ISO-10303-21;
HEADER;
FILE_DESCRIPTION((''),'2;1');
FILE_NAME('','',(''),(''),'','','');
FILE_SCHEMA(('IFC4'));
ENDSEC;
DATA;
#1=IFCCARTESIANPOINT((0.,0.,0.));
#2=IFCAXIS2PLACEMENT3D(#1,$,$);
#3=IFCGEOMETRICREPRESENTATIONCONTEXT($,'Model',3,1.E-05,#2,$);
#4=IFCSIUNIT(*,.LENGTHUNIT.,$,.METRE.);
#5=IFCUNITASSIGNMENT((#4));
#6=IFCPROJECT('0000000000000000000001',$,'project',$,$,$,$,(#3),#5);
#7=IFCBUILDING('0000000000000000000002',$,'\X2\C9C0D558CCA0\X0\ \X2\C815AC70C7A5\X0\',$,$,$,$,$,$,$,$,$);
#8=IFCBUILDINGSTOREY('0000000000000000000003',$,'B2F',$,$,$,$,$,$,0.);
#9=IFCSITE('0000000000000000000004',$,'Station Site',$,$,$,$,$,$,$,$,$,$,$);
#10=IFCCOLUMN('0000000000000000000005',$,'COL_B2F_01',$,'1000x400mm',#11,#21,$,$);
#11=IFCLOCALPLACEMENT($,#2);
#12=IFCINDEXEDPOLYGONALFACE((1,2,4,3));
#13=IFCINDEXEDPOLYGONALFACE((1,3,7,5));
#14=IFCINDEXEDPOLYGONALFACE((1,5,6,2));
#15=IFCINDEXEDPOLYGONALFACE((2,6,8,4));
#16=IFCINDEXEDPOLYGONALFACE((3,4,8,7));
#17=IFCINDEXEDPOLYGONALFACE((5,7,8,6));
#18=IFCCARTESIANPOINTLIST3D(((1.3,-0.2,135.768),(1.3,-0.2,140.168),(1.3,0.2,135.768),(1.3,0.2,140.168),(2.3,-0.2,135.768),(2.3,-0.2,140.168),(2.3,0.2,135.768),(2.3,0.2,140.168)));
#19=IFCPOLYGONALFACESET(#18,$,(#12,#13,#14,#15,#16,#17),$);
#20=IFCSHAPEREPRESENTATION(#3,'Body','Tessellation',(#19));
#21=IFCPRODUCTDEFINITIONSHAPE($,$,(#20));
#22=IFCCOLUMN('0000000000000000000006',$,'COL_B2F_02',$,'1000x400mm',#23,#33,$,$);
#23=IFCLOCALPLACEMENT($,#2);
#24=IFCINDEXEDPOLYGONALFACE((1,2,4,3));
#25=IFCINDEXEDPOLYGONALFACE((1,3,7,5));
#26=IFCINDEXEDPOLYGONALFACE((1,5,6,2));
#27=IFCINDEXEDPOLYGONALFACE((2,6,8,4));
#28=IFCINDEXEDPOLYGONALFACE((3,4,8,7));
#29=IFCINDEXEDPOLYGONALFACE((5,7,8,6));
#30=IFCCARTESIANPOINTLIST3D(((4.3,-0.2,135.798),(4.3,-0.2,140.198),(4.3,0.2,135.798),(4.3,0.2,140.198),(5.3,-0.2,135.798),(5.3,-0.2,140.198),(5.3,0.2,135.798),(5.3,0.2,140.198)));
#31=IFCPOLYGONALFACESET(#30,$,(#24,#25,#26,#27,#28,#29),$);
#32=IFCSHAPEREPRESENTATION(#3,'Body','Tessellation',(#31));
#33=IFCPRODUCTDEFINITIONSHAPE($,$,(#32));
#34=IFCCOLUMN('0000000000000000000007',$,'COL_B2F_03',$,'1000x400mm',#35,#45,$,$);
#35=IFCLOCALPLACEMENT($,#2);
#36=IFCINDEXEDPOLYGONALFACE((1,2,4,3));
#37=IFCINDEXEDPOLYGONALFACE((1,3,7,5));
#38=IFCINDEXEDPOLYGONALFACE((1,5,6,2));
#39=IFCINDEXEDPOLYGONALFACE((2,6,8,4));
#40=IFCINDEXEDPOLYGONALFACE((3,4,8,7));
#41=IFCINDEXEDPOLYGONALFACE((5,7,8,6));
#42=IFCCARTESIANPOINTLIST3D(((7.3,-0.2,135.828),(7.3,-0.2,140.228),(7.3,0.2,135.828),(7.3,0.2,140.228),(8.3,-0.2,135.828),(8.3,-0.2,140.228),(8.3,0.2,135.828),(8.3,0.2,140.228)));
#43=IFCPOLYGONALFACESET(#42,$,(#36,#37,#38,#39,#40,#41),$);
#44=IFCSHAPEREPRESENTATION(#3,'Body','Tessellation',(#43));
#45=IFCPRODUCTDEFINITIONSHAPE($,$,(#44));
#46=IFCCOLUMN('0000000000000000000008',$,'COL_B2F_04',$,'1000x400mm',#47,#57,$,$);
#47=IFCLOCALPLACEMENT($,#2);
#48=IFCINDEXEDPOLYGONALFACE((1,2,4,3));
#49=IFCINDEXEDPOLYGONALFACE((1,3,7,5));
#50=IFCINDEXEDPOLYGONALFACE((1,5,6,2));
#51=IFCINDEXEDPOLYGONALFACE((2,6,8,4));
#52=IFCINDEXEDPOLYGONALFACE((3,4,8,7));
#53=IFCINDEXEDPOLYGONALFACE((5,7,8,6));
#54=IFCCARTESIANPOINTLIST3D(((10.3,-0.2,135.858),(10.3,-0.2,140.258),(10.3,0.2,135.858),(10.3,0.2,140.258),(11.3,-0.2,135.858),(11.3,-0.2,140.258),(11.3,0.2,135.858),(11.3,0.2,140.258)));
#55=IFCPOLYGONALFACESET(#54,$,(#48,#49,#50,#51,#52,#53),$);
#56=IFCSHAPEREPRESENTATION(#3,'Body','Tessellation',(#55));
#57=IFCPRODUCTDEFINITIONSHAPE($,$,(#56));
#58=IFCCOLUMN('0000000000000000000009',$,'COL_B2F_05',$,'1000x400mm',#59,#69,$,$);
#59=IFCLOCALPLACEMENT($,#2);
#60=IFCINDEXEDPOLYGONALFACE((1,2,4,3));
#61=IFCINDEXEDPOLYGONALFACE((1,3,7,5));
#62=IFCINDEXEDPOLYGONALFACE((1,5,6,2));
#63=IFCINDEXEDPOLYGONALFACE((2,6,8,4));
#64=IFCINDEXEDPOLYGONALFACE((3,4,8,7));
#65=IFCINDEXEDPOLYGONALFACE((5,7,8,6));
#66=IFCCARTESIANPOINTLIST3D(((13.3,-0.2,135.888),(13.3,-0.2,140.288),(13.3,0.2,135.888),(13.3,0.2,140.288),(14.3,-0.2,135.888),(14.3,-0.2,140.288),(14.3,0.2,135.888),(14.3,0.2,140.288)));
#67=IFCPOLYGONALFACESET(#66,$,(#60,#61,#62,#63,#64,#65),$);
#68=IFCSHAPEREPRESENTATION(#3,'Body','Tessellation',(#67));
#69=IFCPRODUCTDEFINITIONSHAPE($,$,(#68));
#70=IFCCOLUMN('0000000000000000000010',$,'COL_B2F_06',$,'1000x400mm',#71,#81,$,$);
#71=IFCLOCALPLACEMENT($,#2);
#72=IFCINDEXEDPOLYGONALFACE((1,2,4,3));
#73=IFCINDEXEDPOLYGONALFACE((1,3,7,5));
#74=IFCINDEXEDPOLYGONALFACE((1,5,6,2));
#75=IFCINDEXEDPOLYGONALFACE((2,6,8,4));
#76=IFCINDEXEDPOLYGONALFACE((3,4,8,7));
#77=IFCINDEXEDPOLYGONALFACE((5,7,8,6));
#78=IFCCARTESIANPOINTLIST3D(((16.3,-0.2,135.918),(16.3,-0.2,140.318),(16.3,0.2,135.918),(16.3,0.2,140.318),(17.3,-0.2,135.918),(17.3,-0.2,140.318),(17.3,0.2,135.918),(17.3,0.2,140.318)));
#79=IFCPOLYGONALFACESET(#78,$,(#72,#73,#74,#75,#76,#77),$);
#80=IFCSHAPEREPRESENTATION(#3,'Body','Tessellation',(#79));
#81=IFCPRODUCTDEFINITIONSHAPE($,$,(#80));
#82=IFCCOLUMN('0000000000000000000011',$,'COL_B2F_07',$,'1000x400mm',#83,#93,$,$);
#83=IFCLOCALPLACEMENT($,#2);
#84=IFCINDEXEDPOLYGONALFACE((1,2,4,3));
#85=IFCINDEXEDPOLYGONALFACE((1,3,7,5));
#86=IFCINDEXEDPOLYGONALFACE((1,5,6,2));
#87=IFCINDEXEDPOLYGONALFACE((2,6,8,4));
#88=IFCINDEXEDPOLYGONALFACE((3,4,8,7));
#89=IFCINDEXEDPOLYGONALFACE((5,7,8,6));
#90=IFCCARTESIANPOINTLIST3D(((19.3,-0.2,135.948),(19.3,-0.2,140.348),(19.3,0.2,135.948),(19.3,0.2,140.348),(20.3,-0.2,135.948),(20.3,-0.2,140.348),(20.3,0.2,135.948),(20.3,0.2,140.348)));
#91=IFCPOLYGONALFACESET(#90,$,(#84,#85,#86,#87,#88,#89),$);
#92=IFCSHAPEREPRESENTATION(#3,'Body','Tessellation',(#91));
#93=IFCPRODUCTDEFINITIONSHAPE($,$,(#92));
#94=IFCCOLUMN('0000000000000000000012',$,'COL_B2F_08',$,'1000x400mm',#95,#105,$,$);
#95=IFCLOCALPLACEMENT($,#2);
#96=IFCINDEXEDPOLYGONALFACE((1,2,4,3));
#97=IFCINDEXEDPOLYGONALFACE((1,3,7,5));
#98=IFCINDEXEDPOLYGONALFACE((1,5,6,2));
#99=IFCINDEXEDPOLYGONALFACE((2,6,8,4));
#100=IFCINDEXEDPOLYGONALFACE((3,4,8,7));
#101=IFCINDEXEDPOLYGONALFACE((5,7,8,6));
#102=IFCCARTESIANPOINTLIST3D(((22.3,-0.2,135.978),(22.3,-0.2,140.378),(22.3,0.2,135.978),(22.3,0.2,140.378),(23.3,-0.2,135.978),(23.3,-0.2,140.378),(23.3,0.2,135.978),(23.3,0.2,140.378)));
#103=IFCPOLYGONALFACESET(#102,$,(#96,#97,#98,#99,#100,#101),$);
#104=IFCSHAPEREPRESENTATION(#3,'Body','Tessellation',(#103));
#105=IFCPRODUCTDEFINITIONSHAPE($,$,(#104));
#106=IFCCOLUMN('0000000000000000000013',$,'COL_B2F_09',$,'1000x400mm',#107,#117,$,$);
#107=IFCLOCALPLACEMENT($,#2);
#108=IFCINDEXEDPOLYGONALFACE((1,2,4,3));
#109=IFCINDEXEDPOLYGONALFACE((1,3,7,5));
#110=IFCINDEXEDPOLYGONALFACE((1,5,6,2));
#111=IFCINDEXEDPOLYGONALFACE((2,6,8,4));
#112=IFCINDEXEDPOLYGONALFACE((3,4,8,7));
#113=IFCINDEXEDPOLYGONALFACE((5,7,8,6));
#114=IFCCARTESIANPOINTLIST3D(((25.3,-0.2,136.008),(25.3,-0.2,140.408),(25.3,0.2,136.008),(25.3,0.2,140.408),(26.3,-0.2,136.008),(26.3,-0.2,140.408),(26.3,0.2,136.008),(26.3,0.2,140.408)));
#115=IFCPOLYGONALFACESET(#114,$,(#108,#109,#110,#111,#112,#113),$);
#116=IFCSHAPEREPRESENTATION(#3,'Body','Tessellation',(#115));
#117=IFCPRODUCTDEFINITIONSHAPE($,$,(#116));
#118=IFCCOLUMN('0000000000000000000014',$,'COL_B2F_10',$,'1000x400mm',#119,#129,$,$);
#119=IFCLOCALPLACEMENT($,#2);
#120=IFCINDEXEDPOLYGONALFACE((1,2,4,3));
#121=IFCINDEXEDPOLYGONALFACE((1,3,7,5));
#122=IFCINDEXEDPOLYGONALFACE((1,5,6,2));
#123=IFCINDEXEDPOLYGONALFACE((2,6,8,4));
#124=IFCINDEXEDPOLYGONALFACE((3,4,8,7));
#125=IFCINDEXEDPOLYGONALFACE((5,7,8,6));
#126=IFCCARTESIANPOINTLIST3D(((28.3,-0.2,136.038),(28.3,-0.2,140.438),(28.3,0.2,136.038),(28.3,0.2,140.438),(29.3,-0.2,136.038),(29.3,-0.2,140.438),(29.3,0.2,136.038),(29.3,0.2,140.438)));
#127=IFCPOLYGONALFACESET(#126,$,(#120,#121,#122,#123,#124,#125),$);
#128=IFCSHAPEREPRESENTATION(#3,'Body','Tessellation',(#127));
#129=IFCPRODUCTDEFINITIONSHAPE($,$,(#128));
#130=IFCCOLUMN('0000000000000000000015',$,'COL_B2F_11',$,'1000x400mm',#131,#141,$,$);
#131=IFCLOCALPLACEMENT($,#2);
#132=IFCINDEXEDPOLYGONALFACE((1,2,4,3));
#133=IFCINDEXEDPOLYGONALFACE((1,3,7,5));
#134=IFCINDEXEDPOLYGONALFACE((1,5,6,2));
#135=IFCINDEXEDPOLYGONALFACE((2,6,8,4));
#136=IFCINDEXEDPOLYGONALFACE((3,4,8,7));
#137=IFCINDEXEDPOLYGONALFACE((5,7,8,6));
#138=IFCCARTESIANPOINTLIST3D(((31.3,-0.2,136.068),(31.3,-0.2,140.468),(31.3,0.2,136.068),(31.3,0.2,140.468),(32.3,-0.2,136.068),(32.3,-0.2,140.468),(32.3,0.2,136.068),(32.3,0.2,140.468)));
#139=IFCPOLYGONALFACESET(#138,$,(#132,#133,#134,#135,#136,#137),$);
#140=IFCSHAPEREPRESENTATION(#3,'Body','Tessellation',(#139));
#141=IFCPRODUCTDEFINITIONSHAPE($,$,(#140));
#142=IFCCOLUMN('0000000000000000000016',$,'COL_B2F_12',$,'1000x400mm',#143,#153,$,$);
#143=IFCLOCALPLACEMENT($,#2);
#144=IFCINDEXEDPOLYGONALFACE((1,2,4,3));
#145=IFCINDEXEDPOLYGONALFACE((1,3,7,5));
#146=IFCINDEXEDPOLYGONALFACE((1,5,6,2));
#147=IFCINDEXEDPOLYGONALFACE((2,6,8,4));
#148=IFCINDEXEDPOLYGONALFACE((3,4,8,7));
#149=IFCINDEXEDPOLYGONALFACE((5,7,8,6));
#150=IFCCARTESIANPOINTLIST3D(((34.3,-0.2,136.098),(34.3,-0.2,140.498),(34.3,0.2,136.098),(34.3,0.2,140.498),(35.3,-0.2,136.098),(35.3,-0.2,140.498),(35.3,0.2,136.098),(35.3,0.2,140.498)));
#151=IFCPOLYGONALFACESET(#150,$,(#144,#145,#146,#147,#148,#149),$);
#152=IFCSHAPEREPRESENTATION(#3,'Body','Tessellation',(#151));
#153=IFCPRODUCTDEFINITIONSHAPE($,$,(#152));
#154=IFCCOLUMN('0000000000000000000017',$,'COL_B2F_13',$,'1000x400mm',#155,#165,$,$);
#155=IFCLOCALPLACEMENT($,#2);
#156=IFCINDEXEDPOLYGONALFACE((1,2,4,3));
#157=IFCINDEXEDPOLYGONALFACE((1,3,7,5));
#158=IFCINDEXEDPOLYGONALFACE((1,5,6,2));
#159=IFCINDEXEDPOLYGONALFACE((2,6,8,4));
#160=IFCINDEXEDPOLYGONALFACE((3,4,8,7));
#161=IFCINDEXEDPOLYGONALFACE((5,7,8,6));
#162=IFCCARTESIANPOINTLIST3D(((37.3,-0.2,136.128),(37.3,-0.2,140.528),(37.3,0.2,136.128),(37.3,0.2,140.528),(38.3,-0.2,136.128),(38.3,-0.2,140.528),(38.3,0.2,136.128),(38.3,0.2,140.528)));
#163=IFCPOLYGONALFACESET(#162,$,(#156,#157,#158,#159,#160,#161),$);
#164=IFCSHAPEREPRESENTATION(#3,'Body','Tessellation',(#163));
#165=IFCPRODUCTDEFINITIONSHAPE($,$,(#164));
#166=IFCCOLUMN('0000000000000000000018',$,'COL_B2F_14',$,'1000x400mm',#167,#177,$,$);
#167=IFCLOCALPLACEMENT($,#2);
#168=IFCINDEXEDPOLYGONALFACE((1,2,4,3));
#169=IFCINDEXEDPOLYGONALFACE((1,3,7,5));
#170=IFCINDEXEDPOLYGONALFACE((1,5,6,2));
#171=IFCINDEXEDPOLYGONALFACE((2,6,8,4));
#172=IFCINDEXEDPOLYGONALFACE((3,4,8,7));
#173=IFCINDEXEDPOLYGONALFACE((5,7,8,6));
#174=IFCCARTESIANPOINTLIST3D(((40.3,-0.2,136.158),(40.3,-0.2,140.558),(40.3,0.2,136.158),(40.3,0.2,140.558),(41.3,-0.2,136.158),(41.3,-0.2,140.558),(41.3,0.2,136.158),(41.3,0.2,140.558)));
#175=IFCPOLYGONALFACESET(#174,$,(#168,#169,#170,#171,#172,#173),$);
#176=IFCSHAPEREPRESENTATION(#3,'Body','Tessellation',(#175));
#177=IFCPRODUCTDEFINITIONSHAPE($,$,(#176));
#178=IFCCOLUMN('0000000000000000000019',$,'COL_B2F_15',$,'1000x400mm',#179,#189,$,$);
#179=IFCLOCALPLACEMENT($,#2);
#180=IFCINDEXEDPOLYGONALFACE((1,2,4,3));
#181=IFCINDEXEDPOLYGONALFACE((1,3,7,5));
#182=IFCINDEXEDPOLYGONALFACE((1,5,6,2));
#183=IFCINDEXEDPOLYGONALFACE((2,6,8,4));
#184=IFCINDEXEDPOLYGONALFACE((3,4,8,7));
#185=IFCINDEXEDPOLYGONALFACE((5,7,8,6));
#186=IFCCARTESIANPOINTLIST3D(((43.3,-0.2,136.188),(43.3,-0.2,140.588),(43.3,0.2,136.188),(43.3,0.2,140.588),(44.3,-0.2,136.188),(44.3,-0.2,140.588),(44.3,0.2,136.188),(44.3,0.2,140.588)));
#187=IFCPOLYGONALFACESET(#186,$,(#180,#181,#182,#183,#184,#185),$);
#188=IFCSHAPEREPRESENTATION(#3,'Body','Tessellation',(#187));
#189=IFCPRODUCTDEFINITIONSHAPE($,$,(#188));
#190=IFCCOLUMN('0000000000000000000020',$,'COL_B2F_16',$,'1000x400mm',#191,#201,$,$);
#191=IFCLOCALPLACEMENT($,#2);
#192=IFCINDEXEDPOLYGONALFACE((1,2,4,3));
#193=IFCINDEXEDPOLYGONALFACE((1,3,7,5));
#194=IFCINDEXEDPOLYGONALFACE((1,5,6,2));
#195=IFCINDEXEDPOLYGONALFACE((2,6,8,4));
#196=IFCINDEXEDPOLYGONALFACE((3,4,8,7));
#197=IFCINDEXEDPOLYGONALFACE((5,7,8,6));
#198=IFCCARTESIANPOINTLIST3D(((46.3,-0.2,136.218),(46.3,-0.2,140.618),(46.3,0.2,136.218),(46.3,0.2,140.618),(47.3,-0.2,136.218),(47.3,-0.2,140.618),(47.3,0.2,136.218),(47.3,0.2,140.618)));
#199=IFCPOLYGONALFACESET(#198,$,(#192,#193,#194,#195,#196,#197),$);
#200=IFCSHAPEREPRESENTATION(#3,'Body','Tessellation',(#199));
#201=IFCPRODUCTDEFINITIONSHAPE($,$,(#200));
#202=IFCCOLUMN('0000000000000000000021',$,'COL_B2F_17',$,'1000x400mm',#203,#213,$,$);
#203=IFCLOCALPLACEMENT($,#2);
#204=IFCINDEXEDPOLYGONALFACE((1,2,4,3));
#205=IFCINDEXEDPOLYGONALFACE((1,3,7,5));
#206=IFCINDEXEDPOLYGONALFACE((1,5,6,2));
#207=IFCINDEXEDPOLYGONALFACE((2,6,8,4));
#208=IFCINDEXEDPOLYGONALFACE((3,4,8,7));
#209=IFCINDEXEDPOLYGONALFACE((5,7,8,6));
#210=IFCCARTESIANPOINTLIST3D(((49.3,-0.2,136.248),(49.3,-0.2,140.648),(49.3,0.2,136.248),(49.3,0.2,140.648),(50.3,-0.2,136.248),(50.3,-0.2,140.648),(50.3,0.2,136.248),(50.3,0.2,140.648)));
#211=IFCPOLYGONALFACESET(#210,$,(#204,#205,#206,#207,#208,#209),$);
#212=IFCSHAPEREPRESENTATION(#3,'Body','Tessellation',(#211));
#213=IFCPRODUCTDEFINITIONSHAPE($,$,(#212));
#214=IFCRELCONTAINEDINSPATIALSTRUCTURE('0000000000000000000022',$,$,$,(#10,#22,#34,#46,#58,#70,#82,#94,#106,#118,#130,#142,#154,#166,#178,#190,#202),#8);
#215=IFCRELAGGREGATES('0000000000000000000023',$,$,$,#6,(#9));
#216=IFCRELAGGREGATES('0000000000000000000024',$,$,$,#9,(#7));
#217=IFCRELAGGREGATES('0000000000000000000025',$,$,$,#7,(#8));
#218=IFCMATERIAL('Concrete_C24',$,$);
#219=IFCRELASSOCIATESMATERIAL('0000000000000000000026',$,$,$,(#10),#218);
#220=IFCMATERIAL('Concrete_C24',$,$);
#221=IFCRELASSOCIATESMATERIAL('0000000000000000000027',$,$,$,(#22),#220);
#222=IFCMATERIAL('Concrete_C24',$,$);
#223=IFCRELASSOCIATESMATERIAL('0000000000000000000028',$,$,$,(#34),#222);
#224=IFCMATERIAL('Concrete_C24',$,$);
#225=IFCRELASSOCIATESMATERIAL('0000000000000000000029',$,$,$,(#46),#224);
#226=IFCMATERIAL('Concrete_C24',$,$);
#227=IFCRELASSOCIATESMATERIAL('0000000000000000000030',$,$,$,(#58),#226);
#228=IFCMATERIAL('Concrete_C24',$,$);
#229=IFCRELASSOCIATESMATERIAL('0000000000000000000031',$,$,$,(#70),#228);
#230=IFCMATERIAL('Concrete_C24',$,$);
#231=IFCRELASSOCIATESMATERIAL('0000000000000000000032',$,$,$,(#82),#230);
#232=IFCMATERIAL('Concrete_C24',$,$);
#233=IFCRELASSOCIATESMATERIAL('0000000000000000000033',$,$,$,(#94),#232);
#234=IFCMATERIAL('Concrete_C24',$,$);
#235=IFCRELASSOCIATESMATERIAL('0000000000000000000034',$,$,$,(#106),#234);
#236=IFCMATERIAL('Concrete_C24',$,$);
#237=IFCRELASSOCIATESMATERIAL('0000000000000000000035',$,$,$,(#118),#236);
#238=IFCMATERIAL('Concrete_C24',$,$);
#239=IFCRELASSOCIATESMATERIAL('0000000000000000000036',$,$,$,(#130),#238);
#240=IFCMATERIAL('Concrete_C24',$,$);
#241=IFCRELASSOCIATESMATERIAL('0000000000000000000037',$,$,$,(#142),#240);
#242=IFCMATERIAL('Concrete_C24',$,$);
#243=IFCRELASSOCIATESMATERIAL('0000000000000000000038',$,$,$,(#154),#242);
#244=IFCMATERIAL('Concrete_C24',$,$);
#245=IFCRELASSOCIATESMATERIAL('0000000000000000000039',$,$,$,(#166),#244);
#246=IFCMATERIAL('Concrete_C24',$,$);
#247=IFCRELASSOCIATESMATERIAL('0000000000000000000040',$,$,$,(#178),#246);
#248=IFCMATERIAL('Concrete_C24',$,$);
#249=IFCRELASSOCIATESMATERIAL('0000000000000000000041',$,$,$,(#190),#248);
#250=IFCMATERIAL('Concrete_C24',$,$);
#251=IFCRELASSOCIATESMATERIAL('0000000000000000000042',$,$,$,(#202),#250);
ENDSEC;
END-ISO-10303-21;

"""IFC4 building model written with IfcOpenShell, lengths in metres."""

from ifc_helpers import new_model, si_unit, frame, origin, place, context, project, spatial, rectangle, extrude, material, element, save


model = new_model("IFC4")

# Units and contexts
model_context = context("Model", 3, precision=1e-05, world=origin())
ifc_project = project(units=[si_unit("LENGTHUNIT", "METRE")], contexts=[model_context])

# Site, building, storey
site = spatial("IfcSite", under=ifc_project, Name="Station Site")
building = spatial("IfcBuilding", under=site, Name="지하철 정거장")
storey = spatial("IfcBuildingStorey", under=building, Name="B2F", Elevation=0.0)

# Columns
ifc_material_1 = material(Name="Concrete_C24")
column_1_placement = place(None, frame((1.8, 0.0, 135.768)))
element("IfcColumn", 1, at=column_1_placement, inside=storey, material=ifc_material_1, Name="COL_B2F_01", ObjectType="1000x400mm", context=model_context, shape_type="SweptSolid", body=[
    extrude(rectangle(XDim=1.0, YDim=0.4), origin(), (0.0, 0.0, 1.0), 4.4),
])
ifc_material_2 = material(Name="Concrete_C24")
column_2_placement = place(None, frame((4.8, 0.0, 135.798)))
element("IfcColumn", 2, at=column_2_placement, inside=storey, material=ifc_material_2, Name="COL_B2F_02", ObjectType="1000x400mm", context=model_context, shape_type="SweptSolid", body=[
    extrude(rectangle(XDim=1.0, YDim=0.4), origin(), (0.0, 0.0, 1.0), 4.4),
])
ifc_material_3 = material(Name="Concrete_C24")
column_3_placement = place(None, frame((7.8, 0.0, 135.828)))
element("IfcColumn", 3, at=column_3_placement, inside=storey, material=ifc_material_3, Name="COL_B2F_03", ObjectType="1000x400mm", context=model_context, shape_type="SweptSolid", body=[
    extrude(rectangle(XDim=1.0, YDim=0.4), origin(), (0.0, 0.0, 1.0), 4.4),
])
ifc_material_4 = material(Name="Concrete_C24")
column_4_placement = place(None, frame((10.8, 0.0, 135.858)))
element("IfcColumn", 4, at=column_4_placement, inside=storey, material=ifc_material_4, Name="COL_B2F_04", ObjectType="1000x400mm", context=model_context, shape_type="SweptSolid", body=[
    extrude(rectangle(XDim=1.0, YDim=0.4), origin(), (0.0, 0.0, 1.0), 4.4),
])
ifc_material_5 = material(Name="Concrete_C24")
column_5_placement = place(None, frame((13.8, 0.0, 135.888)))
element("IfcColumn", 5, at=column_5_placement, inside=storey, material=ifc_material_5, Name="COL_B2F_05", ObjectType="1000x400mm", context=model_context, shape_type="SweptSolid", body=[
    extrude(rectangle(XDim=1.0, YDim=0.4), origin(), (0.0, 0.0, 1.0), 4.4),
])
ifc_material_6 = material(Name="Concrete_C24")
column_6_placement = place(None, frame((16.8, 0.0, 135.918)))
element("IfcColumn", 6, at=column_6_placement, inside=storey, material=ifc_material_6, Name="COL_B2F_06", ObjectType="1000x400mm", context=model_context, shape_type="SweptSolid", body=[
    extrude(rectangle(XDim=1.0, YDim=0.4), origin(), (0.0, 0.0, 1.0), 4.4),
])
ifc_material_7 = material(Name="Concrete_C24")
column_7_placement = place(None, frame((19.8, 0.0, 135.948)))
element("IfcColumn", 7, at=column_7_placement, inside=storey, material=ifc_material_7, Name="COL_B2F_07", ObjectType="1000x400mm", context=model_context, shape_type="SweptSolid", body=[
    extrude(rectangle(XDim=1.0, YDim=0.4), origin(), (0.0, 0.0, 1.0), 4.4),
])
ifc_material_8 = material(Name="Concrete_C24")
column_8_placement = place(None, frame((22.8, 0.0, 135.978)))
element("IfcColumn", 8, at=column_8_placement, inside=storey, material=ifc_material_8, Name="COL_B2F_08", ObjectType="1000x400mm", context=model_context, shape_type="SweptSolid", body=[
    extrude(rectangle(XDim=1.0, YDim=0.4), origin(), (0.0, 0.0, 1.0), 4.4),
])
ifc_material_9 = material(Name="Concrete_C24")
column_9_placement = place(None, frame((25.8, 0.0, 136.008)))
element("IfcColumn", 9, at=column_9_placement, inside=storey, material=ifc_material_9, Name="COL_B2F_09", ObjectType="1000x400mm", context=model_context, shape_type="SweptSolid", body=[
    extrude(rectangle(XDim=1.0, YDim=0.4), origin(), (0.0, 0.0, 1.0), 4.4),
])
ifc_material_10 = material(Name="Concrete_C24")
column_10_placement = place(None, frame((28.8, 0.0, 136.038)))
element("IfcColumn", 10, at=column_10_placement, inside=storey, material=ifc_material_10, Name="COL_B2F_10", ObjectType="1000x400mm", context=model_context, shape_type="SweptSolid", body=[
    extrude(rectangle(XDim=1.0, YDim=0.4), origin(), (0.0, 0.0, 1.0), 4.4),
])
ifc_material_11 = material(Name="Concrete_C24")
column_11_placement = place(None, frame((31.8, 0.0, 136.068)))
element("IfcColumn", 11, at=column_11_placement, inside=storey, material=ifc_material_11, Name="COL_B2F_11", ObjectType="1000x400mm", context=model_context, shape_type="SweptSolid", body=[
    extrude(rectangle(XDim=1.0, YDim=0.4), origin(), (0.0, 0.0, 1.0), 4.4),
])
ifc_material_12 = material(Name="Concrete_C24")
column_12_placement = place(None, frame((34.8, 0.0, 136.098)))
element("IfcColumn", 12, at=column_12_placement, inside=storey, material=ifc_material_12, Name="COL_B2F_12", ObjectType="1000x400mm", context=model_context, shape_type="SweptSolid", body=[
    extrude(rectangle(XDim=1.0, YDim=0.4), origin(), (0.0, 0.0, 1.0), 4.4),
])
ifc_material_13 = material(Name="Concrete_C24")
column_13_placement = place(None, frame((37.8, 0.0, 136.128)))
element("IfcColumn", 13, at=column_13_placement, inside=storey, material=ifc_material_13, Name="COL_B2F_13", ObjectType="1000x400mm", context=model_context, shape_type="SweptSolid", body=[
    extrude(rectangle(XDim=1.0, YDim=0.4), origin(), (0.0, 0.0, 1.0), 4.4),
])
ifc_material_14 = material(Name="Concrete_C24")
column_14_placement = place(None, frame((40.8, 0.0, 136.158)))
element("IfcColumn", 14, at=column_14_placement, inside=storey, material=ifc_material_14, Name="COL_B2F_14", ObjectType="1000x400mm", context=model_context, shape_type="SweptSolid", body=[
    extrude(rectangle(XDim=1.0, YDim=0.4), origin(), (0.0, 0.0, 1.0), 4.4),
])
ifc_material_15 = material(Name="Concrete_C24")
column_15_placement = place(None, frame((43.8, 0.0, 136.188)))
element("IfcColumn", 15, at=column_15_placement, inside=storey, material=ifc_material_15, Name="COL_B2F_15", ObjectType="1000x400mm", context=model_context, shape_type="SweptSolid", body=[
    extrude(rectangle(XDim=1.0, YDim=0.4), origin(), (0.0, 0.0, 1.0), 4.4),
])
ifc_material_16 = material(Name="Concrete_C24")
column_16_placement = place(None, frame((46.8, 0.0, 136.218)))
element("IfcColumn", 16, at=column_16_placement, inside=storey, material=ifc_material_16, Name="COL_B2F_16", ObjectType="1000x400mm", context=model_context, shape_type="SweptSolid", body=[
    extrude(rectangle(XDim=1.0, YDim=0.4), origin(), (0.0, 0.0, 1.0), 4.4),
])
ifc_material_17 = material(Name="Concrete_C24")
column_17_placement = place(None, frame((49.8, 0.0, 136.248)))
element("IfcColumn", 17, at=column_17_placement, inside=storey, material=ifc_material_17, Name="COL_B2F_17", ObjectType="1000x400mm", context=model_context, shape_type="SweptSolid", body=[
    extrude(rectangle(XDim=1.0, YDim=0.4), origin(), (0.0, 0.0, 1.0), 4.4),
])

save(model, "model.ifc")
